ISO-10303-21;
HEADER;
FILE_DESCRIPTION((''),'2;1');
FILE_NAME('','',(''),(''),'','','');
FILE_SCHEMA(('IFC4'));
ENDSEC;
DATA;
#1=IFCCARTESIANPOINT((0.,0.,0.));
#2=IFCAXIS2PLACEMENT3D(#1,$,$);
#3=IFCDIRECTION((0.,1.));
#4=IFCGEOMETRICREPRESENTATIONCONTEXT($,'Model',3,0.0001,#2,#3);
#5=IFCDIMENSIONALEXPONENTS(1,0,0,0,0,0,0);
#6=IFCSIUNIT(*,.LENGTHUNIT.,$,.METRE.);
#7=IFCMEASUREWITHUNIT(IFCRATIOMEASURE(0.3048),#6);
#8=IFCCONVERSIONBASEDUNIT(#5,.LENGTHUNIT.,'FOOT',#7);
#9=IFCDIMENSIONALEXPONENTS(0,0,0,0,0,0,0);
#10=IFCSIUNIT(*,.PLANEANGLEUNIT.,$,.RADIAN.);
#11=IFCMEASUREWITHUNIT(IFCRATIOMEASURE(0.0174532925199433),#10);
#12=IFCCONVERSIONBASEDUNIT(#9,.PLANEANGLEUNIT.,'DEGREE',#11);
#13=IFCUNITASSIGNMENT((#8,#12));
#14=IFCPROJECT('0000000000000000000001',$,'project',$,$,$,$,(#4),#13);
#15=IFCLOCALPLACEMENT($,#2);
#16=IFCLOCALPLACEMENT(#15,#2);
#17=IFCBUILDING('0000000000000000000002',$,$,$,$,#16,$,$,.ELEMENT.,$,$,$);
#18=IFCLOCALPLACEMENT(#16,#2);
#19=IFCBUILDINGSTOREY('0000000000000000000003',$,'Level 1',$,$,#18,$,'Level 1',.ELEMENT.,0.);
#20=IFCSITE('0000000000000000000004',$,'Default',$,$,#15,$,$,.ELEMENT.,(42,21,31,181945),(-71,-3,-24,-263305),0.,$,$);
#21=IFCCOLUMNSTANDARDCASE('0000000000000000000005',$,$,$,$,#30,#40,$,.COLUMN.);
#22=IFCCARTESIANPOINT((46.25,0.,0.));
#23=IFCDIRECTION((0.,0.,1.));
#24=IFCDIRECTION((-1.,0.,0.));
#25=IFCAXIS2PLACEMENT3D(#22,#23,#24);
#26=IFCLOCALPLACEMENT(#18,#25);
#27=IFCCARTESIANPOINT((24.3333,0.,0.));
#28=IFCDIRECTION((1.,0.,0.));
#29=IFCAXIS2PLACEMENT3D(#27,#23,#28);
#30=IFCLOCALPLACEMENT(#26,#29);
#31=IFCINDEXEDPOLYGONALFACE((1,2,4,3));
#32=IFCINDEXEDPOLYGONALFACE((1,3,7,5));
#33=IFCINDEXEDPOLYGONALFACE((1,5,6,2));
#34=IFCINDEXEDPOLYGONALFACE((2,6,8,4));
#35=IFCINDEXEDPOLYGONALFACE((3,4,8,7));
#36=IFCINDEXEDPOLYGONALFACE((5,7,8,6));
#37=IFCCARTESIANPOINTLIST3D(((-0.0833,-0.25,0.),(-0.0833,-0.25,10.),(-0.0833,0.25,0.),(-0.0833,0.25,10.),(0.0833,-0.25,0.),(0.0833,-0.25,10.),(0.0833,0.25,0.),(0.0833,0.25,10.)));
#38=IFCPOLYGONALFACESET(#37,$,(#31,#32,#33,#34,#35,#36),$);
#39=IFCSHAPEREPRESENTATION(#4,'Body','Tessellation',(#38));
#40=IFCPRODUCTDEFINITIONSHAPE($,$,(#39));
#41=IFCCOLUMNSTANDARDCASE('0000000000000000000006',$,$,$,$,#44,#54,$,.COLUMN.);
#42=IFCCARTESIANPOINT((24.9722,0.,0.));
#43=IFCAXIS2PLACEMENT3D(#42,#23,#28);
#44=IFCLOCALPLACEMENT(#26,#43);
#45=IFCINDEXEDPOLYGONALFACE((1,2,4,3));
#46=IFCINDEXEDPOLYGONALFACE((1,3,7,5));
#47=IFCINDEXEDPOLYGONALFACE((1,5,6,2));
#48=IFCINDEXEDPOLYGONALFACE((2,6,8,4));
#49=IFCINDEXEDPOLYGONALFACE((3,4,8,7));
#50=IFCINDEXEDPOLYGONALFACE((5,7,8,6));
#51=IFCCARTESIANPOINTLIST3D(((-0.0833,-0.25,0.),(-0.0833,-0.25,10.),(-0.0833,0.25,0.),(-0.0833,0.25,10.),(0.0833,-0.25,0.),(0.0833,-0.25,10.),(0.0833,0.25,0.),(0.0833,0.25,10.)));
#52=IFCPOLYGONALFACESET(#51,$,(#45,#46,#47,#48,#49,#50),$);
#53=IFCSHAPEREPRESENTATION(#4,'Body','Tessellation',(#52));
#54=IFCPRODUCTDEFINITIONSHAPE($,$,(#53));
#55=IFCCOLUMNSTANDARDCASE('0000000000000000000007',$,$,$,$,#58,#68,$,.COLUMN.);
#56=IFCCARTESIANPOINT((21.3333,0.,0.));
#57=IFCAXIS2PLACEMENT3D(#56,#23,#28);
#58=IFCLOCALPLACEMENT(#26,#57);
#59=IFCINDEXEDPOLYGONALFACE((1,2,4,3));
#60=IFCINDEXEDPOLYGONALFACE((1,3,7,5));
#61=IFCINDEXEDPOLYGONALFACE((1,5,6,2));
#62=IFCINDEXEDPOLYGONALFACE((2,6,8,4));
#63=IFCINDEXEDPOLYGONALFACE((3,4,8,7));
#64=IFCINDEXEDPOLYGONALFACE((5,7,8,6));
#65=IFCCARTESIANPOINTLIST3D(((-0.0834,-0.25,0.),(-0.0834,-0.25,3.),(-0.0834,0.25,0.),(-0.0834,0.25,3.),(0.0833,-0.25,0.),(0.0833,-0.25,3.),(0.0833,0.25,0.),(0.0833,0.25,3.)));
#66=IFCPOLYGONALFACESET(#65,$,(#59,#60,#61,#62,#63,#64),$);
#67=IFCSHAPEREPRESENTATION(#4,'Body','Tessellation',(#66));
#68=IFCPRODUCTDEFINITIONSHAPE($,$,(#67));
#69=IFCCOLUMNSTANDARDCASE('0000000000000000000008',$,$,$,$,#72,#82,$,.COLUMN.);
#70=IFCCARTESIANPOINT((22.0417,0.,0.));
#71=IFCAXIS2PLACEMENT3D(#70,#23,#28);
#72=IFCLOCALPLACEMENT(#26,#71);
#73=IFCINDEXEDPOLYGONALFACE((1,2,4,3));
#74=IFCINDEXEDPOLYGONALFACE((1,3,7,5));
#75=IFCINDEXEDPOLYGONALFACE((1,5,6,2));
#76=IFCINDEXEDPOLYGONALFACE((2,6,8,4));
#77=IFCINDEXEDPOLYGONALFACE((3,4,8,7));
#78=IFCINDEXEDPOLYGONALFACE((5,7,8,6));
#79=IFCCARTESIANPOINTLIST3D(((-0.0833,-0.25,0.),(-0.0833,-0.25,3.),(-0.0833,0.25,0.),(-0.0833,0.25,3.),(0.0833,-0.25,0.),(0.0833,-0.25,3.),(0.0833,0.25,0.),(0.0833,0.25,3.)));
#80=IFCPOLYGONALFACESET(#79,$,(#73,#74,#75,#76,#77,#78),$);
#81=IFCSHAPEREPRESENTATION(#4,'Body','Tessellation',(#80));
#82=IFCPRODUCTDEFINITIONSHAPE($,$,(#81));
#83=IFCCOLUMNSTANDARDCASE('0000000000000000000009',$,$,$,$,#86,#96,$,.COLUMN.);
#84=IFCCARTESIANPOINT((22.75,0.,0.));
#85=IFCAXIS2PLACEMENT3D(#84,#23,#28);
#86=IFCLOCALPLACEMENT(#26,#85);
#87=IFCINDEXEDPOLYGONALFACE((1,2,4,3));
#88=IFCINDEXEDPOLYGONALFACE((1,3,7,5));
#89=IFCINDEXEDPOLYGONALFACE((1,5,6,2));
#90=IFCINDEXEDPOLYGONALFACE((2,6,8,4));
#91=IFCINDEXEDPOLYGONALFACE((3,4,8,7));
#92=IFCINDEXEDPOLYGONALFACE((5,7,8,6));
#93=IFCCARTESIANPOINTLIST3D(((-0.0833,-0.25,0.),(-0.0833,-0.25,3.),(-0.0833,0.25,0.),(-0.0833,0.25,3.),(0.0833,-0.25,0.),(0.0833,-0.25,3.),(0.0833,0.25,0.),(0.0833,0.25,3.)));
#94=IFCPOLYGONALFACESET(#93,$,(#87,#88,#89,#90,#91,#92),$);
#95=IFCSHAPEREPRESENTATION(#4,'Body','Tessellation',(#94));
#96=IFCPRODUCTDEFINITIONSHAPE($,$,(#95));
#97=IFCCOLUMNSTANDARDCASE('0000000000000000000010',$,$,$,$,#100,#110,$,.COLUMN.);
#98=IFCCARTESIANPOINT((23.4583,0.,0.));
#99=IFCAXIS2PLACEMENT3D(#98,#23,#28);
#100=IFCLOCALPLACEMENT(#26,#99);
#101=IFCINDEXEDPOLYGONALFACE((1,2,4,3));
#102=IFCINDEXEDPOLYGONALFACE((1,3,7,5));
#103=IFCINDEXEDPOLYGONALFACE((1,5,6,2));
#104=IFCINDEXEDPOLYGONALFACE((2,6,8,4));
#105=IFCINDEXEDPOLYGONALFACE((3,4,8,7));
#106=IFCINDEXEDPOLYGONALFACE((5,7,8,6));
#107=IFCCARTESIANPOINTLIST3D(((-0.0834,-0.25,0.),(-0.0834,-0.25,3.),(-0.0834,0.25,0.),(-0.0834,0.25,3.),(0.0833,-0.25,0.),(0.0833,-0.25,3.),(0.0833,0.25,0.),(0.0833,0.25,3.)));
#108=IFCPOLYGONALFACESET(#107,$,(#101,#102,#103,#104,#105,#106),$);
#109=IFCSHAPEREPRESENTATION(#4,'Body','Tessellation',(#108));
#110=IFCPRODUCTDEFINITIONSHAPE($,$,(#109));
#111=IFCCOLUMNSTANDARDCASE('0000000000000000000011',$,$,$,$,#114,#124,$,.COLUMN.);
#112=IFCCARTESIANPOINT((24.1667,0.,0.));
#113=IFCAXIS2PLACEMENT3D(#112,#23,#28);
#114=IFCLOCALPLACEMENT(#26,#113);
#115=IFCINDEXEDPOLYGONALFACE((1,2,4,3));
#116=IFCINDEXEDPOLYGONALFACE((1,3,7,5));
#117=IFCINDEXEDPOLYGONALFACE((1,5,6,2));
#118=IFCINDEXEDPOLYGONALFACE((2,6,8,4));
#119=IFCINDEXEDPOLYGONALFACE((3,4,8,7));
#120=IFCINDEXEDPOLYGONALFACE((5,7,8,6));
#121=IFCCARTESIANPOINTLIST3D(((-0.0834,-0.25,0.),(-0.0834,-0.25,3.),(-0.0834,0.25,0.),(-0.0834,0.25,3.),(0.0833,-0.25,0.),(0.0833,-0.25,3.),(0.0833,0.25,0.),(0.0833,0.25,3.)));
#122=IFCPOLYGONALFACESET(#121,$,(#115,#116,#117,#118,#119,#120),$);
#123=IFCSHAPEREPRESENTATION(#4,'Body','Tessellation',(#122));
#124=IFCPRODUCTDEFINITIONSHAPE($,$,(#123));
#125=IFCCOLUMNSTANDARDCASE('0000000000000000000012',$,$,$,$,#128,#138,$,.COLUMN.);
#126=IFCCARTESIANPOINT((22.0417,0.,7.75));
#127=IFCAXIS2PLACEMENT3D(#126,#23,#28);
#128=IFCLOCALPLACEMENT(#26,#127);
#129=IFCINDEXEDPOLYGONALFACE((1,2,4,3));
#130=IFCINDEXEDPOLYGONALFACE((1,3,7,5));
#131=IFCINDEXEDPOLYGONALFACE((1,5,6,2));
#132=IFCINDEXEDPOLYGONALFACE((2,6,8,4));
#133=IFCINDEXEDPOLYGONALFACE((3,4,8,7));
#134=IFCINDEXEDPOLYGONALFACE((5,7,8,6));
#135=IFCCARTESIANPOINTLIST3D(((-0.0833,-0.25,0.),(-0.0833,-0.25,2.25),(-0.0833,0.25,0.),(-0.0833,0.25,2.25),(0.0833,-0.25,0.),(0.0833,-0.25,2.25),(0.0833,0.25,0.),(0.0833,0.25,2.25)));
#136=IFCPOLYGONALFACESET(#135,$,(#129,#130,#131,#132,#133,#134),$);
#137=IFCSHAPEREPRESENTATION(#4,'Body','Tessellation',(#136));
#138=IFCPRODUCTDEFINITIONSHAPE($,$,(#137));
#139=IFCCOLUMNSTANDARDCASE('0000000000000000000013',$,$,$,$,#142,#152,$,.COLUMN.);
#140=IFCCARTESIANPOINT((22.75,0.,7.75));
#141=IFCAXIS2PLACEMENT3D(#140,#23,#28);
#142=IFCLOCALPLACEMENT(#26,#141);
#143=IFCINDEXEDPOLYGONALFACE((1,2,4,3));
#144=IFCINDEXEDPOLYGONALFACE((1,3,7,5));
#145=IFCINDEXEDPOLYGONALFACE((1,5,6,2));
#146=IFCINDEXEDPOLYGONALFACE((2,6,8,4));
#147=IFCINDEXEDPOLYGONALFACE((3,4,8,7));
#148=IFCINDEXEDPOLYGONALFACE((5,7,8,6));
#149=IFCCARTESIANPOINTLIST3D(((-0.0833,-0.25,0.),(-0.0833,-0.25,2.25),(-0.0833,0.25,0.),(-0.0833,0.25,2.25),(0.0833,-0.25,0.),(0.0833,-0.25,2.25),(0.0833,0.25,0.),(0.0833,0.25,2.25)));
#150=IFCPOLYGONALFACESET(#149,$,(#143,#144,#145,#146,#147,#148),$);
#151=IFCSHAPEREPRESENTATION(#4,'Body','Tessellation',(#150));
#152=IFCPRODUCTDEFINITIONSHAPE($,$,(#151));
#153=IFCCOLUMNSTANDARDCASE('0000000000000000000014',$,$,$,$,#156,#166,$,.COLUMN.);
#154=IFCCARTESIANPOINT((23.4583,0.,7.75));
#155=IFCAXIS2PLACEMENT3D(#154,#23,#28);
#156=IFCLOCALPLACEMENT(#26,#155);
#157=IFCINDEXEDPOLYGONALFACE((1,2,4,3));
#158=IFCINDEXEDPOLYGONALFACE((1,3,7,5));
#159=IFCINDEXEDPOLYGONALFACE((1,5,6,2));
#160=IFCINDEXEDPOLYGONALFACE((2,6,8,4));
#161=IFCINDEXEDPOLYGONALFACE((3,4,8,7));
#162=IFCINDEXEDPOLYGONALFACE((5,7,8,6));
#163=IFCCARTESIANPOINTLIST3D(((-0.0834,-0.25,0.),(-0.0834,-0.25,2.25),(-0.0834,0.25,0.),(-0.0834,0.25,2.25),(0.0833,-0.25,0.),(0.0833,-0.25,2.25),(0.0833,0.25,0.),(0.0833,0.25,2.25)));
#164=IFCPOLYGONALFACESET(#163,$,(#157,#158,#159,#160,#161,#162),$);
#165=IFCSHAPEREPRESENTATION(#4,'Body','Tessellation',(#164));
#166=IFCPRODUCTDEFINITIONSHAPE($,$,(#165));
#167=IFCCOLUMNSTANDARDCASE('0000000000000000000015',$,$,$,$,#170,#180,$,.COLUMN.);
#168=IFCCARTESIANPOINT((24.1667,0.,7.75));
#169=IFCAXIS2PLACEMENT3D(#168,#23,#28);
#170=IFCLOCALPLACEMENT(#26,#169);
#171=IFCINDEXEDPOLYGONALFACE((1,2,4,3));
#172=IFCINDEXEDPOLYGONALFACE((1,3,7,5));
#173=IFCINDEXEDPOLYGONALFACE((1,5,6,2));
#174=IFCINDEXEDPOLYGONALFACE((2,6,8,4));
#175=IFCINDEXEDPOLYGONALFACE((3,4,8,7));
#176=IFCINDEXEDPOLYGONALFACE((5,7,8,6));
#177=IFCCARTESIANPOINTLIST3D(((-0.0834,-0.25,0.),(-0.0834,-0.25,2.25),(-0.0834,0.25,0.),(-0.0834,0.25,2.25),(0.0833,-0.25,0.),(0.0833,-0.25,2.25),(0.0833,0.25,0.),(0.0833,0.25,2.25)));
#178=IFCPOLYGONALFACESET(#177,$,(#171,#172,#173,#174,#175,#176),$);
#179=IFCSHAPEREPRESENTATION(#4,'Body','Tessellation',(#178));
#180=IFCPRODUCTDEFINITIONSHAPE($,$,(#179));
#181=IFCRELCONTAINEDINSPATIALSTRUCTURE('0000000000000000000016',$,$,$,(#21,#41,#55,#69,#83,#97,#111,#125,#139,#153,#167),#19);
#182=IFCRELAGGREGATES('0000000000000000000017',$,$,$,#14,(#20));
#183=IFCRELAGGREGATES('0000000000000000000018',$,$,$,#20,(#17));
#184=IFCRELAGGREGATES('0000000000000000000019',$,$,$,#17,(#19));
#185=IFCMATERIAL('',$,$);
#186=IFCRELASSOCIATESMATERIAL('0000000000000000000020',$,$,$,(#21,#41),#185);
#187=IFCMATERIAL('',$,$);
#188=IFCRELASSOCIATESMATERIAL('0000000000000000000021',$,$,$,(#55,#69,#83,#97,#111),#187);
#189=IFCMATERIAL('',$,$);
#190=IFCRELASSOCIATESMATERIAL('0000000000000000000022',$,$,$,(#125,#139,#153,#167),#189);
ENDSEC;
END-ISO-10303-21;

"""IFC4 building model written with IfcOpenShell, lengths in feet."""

from ifc_helpers import new_model, entity, si_unit, converted_unit, direction, frame, origin, place, context, project, spatial, rectangle, extrude, material, element, save


model = new_model("IFC4")

# Units and contexts
model_context = context("Model", 3, precision=0.0001, world=origin(), true_north=direction((0.0, 1.0)))
ifc_project = project(units=[converted_unit("LENGTHUNIT", "FOOT", entity("IfcRatioMeasure", 0.3048), si_unit("LENGTHUNIT", "METRE"), dimensions=[1, 0, 0, 0, 0, 0, 0]), converted_unit("PLANEANGLEUNIT", "DEGREE", entity("IfcRatioMeasure", 0.0174532925199433), si_unit("PLANEANGLEUNIT", "RADIAN"), dimensions=[0, 0, 0, 0, 0, 0, 0])], contexts=[model_context])

# Site, building, storey
site_placement = place(None, origin())
site = spatial("IfcSite", under=ifc_project, at=site_placement, Name="Default", CompositionType="ELEMENT", RefLatitude=(42, 21, 31, 181945), RefLongitude=(-71, -3, -24, -263305), RefElevation=0.0)
building_placement = place(site_placement, origin())
building = spatial("IfcBuilding", under=site, at=building_placement, CompositionType="ELEMENT")
storey_placement = place(building_placement, origin())
storey = spatial("IfcBuildingStorey", under=building, at=storey_placement, Name="Level 1", LongName="Level 1", CompositionType="ELEMENT", Elevation=0.0)

# Columns
ifc_material_1 = material(Name="")
placement = place(storey_placement, frame((46.25, 0.0, 0.0), z_axis=(0.0, 0.0, 1.0), x_axis=(-1.0, 0.0, 0.0)))
for number, where, z_axis, x_axis in (
    (1, (24.3333, 0.0, 0.0), (0.0, 0.0, 1.0), (1.0, 0.0, 0.0)),
    (2, (24.9722, 0.0, 0.0), (0.0, 0.0, 1.0), (1.0, 0.0, 0.0)),
):
    element("IfcColumnStandardCase", number, at=place(placement, frame(where, z_axis=z_axis, x_axis=x_axis)), inside=storey, material=ifc_material_1, PredefinedType="COLUMN", context=model_context, shape_type="SweptSolid", body=[
        extrude(rectangle(XDim=0.1667, YDim=0.5), origin(), (0.0, 0.0, 1.0), 10.0),
    ])
ifc_material_2 = material(Name="")
for number, where, z_axis, x_axis in (
    (3, (21.3333, 0.0, 0.0), (0.0, 0.0, 1.0), (1.0, 0.0, 0.0)),
    (4, (22.0417, 0.0, 0.0), (0.0, 0.0, 1.0), (1.0, 0.0, 0.0)),
    (5, (22.75, 0.0, 0.0), (0.0, 0.0, 1.0), (1.0, 0.0, 0.0)),
    (6, (23.4583, 0.0, 0.0), (0.0, 0.0, 1.0), (1.0, 0.0, 0.0)),
    (7, (24.1667, 0.0, 0.0), (0.0, 0.0, 1.0), (1.0, 0.0, 0.0)),
):
    element("IfcColumnStandardCase", number, at=place(placement, frame(where, z_axis=z_axis, x_axis=x_axis)), inside=storey, material=ifc_material_2, PredefinedType="COLUMN", context=model_context, shape_type="SweptSolid", body=[
        extrude(rectangle(XDim=0.1667, YDim=0.5), origin(), (0.0, 0.0, 1.0), 3.0),
    ])
ifc_material_3 = material(Name="")
for number, where, z_axis, x_axis in (
    (8, (22.0417, 0.0, 7.75), (0.0, 0.0, 1.0), (1.0, 0.0, 0.0)),
    (9, (22.75, 0.0, 7.75), (0.0, 0.0, 1.0), (1.0, 0.0, 0.0)),
    (10, (23.4583, 0.0, 7.75), (0.0, 0.0, 1.0), (1.0, 0.0, 0.0)),
    (11, (24.1667, 0.0, 7.75), (0.0, 0.0, 1.0), (1.0, 0.0, 0.0)),
):
    element("IfcColumnStandardCase", number, at=place(placement, frame(where, z_axis=z_axis, x_axis=x_axis)), inside=storey, material=ifc_material_3, PredefinedType="COLUMN", context=model_context, shape_type="SweptSolid", body=[
        extrude(rectangle(XDim=0.1667, YDim=0.5), origin(), (0.0, 0.0, 1.0), 2.25),
    ])

save(model, "model.ifc")
